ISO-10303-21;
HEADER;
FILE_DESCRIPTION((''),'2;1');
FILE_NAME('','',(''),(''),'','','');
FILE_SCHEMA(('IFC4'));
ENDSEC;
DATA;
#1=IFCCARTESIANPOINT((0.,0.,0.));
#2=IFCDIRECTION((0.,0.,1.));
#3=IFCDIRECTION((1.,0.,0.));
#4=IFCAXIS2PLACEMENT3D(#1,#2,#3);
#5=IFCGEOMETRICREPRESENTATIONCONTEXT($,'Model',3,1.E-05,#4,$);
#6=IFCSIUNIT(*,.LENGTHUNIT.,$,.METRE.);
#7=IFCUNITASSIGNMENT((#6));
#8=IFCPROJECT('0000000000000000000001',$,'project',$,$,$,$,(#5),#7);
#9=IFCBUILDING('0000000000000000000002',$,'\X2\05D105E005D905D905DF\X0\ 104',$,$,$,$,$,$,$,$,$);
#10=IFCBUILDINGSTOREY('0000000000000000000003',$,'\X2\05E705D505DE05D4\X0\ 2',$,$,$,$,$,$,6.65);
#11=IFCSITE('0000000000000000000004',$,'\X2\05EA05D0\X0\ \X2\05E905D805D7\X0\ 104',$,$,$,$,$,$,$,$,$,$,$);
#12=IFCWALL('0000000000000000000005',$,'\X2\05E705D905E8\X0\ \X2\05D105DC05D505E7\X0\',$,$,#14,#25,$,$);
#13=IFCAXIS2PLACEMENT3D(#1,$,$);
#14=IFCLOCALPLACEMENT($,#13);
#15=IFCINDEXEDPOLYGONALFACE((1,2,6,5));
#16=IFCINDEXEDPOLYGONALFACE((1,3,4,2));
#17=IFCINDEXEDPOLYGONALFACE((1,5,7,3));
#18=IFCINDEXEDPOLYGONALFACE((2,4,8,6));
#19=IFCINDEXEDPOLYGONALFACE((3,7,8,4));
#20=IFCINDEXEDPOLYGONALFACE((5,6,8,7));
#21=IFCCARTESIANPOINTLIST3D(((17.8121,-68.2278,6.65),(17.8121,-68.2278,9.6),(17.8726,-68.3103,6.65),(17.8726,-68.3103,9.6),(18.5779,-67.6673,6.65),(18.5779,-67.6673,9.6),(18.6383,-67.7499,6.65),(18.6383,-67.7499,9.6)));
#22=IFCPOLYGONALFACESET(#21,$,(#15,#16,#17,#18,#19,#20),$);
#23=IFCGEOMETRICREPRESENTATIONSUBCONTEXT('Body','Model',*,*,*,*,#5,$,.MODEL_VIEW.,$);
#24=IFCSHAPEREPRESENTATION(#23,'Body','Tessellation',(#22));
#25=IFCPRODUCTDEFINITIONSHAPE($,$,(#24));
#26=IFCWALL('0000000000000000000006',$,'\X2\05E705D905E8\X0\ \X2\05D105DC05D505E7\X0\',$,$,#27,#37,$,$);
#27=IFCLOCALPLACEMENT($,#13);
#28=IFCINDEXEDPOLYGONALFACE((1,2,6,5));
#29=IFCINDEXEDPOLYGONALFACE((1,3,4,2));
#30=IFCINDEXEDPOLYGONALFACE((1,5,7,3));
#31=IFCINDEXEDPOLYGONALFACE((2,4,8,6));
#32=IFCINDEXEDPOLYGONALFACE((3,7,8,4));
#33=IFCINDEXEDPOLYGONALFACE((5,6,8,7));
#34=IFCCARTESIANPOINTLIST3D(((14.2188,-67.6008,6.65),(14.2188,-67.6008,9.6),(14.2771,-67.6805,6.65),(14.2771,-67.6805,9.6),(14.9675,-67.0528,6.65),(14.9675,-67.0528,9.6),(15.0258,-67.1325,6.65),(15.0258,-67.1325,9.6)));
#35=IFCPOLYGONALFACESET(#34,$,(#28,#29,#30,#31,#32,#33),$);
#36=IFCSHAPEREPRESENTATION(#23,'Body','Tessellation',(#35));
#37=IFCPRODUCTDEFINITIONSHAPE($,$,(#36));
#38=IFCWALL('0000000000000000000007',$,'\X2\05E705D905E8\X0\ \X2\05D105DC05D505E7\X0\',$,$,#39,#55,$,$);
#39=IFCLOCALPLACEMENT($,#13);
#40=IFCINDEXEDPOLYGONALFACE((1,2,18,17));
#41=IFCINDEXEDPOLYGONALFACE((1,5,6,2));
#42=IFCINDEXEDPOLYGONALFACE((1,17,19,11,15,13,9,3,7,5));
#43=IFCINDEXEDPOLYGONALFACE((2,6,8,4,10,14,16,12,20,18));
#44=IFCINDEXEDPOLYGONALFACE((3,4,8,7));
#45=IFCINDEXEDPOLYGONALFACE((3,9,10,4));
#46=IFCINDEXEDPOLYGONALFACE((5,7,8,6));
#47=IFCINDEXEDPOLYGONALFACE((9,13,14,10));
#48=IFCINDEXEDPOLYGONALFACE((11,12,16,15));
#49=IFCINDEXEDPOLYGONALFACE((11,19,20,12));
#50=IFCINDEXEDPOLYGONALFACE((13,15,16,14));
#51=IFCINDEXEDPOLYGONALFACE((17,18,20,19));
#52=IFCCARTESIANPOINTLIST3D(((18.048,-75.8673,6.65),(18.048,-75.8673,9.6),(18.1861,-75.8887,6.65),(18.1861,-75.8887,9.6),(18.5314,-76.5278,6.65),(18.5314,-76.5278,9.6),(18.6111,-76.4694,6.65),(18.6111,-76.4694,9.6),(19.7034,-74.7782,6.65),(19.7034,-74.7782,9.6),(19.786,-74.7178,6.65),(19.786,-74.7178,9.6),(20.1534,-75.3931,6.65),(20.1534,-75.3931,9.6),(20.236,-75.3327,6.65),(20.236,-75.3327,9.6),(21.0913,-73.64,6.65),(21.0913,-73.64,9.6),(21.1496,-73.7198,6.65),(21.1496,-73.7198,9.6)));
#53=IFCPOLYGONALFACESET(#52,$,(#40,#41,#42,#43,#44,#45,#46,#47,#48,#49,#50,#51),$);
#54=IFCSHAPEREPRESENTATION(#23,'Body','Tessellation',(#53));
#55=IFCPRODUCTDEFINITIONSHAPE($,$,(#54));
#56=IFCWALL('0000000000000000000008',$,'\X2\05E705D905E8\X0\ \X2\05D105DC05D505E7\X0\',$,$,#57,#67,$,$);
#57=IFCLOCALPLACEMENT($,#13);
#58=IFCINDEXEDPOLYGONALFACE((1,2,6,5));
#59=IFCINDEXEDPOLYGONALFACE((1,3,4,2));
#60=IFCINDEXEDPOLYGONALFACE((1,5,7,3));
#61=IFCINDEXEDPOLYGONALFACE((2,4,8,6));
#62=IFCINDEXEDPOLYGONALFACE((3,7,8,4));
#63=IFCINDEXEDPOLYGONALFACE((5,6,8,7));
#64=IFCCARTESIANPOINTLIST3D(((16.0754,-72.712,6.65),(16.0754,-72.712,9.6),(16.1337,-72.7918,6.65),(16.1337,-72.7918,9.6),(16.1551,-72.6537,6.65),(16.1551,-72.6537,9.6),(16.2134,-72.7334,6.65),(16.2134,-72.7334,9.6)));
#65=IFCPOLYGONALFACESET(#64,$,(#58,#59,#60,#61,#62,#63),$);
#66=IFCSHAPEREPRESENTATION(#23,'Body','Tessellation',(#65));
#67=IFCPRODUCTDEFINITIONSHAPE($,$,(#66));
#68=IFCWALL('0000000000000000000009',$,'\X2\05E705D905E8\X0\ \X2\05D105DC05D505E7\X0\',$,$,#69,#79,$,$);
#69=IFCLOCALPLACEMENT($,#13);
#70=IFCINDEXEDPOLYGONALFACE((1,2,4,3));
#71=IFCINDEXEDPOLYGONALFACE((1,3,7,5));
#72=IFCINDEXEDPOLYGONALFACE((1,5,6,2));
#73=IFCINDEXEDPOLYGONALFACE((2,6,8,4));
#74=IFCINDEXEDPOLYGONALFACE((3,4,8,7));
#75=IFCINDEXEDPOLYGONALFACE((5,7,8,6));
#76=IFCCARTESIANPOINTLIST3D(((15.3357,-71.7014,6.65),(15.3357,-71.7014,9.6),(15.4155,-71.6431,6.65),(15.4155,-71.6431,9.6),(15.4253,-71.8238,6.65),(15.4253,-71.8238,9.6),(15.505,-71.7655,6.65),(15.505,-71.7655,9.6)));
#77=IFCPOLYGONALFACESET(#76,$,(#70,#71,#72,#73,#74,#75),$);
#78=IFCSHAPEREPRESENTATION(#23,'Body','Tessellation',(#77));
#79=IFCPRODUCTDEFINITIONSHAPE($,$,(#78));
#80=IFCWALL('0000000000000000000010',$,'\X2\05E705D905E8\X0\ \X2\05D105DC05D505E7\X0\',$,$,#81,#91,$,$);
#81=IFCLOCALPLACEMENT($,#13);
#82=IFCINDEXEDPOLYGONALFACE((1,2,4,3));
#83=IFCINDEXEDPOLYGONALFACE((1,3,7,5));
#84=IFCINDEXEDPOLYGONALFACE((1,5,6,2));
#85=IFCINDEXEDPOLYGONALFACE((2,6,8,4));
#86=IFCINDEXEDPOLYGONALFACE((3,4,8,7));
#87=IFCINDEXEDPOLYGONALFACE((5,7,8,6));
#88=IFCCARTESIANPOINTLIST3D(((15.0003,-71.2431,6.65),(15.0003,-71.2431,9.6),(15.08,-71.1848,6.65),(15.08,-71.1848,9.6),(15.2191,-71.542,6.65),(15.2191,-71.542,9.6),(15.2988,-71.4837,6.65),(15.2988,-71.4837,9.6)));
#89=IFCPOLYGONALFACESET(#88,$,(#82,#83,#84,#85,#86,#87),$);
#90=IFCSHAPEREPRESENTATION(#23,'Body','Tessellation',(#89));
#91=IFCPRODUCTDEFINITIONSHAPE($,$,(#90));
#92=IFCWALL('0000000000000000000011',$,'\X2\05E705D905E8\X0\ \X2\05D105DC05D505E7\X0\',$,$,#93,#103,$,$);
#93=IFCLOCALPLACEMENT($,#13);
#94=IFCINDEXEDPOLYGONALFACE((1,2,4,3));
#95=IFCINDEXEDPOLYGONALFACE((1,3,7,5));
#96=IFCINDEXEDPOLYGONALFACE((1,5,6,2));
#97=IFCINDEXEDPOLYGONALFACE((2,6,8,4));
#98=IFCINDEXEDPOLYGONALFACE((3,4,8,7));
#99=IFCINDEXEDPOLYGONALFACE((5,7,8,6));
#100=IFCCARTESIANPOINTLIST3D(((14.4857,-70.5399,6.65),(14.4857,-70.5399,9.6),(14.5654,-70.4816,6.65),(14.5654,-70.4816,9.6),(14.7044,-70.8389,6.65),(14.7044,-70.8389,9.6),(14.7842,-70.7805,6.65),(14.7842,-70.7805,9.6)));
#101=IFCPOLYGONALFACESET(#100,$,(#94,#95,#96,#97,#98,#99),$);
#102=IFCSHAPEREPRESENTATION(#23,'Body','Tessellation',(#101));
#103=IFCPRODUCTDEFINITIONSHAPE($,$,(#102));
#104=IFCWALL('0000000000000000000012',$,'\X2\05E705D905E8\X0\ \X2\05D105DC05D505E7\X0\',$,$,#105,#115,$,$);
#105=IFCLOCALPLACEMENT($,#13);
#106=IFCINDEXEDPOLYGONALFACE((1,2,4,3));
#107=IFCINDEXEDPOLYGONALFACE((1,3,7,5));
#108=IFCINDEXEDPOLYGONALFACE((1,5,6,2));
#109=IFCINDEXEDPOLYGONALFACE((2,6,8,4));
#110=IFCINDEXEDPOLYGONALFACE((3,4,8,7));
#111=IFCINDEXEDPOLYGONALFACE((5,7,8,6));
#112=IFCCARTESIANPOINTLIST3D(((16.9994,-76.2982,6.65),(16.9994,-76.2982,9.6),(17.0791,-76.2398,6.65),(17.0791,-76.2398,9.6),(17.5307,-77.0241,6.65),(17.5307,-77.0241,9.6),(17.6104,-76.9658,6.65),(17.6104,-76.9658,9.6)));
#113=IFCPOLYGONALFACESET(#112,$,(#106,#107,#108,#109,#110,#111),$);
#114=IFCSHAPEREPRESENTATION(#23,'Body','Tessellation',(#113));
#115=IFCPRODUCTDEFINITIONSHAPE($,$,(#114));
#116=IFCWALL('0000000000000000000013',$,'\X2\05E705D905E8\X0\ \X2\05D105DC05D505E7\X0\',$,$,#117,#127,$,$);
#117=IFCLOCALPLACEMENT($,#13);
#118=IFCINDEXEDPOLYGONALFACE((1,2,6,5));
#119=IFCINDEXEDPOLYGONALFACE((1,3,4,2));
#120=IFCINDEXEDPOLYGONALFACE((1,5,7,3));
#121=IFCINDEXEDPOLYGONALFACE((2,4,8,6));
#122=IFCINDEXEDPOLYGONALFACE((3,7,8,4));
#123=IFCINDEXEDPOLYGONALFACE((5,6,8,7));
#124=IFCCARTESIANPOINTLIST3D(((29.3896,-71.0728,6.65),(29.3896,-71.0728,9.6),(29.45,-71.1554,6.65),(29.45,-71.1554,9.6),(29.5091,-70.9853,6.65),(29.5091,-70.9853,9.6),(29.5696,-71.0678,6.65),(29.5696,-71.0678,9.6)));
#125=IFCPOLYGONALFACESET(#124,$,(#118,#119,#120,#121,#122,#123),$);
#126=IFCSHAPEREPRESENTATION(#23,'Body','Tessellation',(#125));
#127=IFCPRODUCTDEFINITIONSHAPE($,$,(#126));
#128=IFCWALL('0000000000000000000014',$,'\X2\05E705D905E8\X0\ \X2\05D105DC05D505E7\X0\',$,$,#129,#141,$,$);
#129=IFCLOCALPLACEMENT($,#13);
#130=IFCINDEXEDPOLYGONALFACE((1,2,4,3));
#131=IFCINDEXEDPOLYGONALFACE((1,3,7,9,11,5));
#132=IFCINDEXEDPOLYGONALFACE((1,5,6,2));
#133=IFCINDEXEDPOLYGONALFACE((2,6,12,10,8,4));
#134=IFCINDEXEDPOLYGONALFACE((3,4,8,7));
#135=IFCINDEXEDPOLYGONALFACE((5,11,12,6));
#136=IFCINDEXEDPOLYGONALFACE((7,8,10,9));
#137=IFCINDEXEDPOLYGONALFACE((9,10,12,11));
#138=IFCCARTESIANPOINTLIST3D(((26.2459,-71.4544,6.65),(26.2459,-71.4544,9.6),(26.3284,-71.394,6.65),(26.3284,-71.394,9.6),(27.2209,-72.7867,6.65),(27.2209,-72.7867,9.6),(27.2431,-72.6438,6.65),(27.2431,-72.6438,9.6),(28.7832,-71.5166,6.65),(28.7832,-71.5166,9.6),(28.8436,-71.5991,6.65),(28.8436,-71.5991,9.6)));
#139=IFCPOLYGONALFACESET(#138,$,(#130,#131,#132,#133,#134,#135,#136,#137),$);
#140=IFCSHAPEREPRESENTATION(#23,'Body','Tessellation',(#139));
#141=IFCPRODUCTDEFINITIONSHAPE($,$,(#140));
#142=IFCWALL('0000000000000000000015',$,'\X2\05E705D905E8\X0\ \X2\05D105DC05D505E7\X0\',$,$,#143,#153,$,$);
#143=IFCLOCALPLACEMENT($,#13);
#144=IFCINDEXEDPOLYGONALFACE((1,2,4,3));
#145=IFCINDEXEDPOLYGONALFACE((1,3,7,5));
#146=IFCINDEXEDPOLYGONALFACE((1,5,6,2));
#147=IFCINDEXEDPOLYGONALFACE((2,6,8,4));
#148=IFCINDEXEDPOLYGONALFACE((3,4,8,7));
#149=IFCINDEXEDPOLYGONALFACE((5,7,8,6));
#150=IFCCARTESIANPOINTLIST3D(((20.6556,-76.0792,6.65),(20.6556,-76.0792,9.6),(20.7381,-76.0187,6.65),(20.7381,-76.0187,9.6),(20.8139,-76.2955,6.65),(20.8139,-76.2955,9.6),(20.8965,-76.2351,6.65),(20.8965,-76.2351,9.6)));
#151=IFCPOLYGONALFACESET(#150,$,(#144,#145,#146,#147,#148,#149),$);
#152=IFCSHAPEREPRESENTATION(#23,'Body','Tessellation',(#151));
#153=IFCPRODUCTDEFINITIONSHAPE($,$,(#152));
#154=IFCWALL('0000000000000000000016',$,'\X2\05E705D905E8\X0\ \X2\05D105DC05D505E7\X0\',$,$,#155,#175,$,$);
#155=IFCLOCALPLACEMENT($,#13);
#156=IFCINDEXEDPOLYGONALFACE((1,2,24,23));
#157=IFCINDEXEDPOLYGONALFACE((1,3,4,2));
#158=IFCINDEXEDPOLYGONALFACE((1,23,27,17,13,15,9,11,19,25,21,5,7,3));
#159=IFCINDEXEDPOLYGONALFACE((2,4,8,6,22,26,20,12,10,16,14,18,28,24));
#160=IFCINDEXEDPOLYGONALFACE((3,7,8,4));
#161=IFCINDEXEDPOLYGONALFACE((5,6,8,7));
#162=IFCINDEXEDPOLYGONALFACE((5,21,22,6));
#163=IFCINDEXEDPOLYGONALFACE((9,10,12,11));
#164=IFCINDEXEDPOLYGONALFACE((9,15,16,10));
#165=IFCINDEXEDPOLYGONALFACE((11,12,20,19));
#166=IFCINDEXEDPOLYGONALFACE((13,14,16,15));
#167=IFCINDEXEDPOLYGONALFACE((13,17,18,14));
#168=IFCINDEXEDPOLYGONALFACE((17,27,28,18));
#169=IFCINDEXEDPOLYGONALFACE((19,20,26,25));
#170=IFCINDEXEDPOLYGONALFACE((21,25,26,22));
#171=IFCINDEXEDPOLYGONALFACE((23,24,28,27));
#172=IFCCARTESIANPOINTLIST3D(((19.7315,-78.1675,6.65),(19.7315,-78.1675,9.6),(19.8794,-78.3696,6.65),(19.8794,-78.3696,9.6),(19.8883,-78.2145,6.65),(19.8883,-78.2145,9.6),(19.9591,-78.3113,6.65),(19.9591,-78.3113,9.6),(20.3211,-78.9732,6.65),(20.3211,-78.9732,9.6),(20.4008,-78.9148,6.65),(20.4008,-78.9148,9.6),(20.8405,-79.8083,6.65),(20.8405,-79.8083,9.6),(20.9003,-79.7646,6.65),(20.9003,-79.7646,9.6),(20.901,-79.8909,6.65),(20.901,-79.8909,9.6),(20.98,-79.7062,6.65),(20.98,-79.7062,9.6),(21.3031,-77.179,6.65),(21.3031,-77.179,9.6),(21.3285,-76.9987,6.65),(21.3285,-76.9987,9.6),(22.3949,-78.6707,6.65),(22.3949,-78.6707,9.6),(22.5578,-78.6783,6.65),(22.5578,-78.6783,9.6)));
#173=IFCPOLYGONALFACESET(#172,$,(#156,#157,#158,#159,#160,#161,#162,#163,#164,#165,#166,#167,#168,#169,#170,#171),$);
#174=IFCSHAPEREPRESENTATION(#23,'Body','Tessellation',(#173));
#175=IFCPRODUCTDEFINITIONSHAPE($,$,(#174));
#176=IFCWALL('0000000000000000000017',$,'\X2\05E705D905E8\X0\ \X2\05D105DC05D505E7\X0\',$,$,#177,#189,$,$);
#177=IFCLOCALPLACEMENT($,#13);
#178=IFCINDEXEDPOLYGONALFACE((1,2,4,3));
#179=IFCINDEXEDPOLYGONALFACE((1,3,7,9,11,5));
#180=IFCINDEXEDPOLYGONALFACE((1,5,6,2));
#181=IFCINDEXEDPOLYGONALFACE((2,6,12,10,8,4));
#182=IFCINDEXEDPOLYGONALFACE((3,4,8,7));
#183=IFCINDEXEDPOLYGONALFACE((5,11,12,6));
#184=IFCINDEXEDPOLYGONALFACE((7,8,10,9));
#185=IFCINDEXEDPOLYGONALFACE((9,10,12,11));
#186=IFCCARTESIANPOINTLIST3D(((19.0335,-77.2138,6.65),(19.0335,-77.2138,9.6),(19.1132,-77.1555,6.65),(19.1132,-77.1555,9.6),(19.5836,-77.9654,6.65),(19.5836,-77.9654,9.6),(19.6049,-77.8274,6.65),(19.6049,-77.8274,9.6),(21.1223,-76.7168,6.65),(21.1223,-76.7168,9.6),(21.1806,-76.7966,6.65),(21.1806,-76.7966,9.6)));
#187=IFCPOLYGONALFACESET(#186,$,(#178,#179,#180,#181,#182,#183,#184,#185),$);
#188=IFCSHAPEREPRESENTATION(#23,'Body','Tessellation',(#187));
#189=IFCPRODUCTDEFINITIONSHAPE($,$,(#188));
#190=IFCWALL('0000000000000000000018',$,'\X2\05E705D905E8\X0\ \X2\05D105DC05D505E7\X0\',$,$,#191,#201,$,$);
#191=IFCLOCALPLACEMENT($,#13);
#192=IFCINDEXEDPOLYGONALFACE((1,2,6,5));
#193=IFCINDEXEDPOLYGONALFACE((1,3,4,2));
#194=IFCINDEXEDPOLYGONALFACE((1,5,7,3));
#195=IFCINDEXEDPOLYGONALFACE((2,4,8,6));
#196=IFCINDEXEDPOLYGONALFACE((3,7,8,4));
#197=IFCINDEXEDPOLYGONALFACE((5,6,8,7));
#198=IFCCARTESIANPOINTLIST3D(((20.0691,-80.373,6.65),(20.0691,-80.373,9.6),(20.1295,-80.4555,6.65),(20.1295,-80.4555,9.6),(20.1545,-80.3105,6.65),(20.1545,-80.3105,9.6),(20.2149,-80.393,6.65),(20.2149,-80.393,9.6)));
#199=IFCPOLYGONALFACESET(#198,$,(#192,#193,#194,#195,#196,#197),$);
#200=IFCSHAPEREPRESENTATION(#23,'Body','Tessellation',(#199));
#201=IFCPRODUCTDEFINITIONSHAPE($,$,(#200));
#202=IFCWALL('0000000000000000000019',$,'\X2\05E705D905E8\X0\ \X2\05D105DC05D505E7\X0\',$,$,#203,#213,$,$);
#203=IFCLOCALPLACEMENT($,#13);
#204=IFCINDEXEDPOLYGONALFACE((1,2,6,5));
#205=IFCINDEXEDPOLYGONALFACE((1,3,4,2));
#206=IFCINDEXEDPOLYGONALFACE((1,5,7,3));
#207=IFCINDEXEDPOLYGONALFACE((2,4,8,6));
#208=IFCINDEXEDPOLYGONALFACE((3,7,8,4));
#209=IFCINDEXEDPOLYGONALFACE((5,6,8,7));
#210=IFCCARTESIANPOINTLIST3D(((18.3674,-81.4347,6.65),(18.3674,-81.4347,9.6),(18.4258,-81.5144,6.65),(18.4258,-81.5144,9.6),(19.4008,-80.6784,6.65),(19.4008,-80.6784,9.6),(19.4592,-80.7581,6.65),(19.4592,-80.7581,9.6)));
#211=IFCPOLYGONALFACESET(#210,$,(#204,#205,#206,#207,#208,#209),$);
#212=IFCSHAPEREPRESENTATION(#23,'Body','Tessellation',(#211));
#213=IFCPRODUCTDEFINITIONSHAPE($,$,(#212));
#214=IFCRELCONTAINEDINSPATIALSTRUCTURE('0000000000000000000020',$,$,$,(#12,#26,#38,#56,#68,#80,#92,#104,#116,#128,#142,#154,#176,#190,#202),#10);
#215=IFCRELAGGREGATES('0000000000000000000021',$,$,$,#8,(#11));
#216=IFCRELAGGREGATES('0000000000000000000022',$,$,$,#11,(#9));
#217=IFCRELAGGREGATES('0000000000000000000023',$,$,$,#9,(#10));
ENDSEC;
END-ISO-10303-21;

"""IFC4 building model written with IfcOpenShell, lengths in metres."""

from ifc_helpers import new_model, si_unit, frame, origin_with_axes, context, subcontext, project, spatial, polyline, outline, extrude, element, save


model = new_model("IFC4")

# Units and contexts
model_context = context("Model", 3, precision=1e-05, world=origin_with_axes())
body_context = subcontext(model_context, "Body", "Model", "MODEL_VIEW")
ifc_project = project(units=[si_unit("LENGTHUNIT", "METRE")], contexts=[model_context])

# Site, building, storey
site = spatial("IfcSite", under=ifc_project, Name="תא שטח 104")
building = spatial("IfcBuilding", under=site, Name="בניין 104")
storey = spatial("IfcBuildingStorey", under=building, Name="קומה 2", Elevation=6.65)

# Walls
element("IfcWall", 1, inside=storey, Name="קיר בלוק", context=body_context, shape_type="SweptSolid", body=[
    extrude(outline(polyline([(18.5779, -67.6673), (17.8121, -68.2278), (17.8726, -68.3103), (18.6383, -67.7499), (18.5779, -67.6673)])), frame((0.0, 0.0, 6.65)), (0.0, 0.0, 1.0), 2.95),
])
element("IfcWall", 2, inside=storey, Name="קיר בלוק", context=body_context, shape_type="SweptSolid", body=[
    extrude(outline(polyline([(14.2188, -67.6008), (14.2771, -67.6805), (15.0258, -67.1325), (14.9675, -67.0528), (14.2188, -67.6008)])), frame((0.0, 0.0, 6.65)), (0.0, 0.0, 1.0), 2.95),
])
element("IfcWall", 3, inside=storey, Name="קיר בלוק", context=body_context, shape_type="SweptSolid", body=[
    extrude(outline(polyline([(21.0913, -73.64), (18.048, -75.8673), (18.5314, -76.5278), (18.6111, -76.4694), (18.1861, -75.8887), (19.7034, -74.7782), (20.1534, -75.3931), (20.236, -75.3327), (19.786, -74.7178), (21.1496, -73.7198), (21.0913, -73.64)])), frame((0.0, 0.0, 6.65)), (0.0, 0.0, 1.0), 2.95),
])
element("IfcWall", 4, inside=storey, Name="קיר בלוק", context=body_context, shape_type="SweptSolid", body=[
    extrude(outline(polyline([(16.1551, -72.6537), (16.0754, -72.712), (16.1337, -72.7918), (16.2134, -72.7334), (16.1551, -72.6537)])), frame((0.0, 0.0, 6.65)), (0.0, 0.0, 1.0), 2.95),
])
element("IfcWall", 5, inside=storey, Name="קיר בלוק", context=body_context, shape_type="SweptSolid", body=[
    extrude(outline(polyline([(15.505, -71.7655), (15.4155, -71.6431), (15.3357, -71.7014), (15.4253, -71.8238), (15.505, -71.7655)])), frame((0.0, 0.0, 6.65)), (0.0, 0.0, 1.0), 2.95),
])
element("IfcWall", 6, inside=storey, Name="קיר בלוק", context=body_context, shape_type="SweptSolid", body=[
    extrude(outline(polyline([(15.2988, -71.4837), (15.08, -71.1848), (15.0003, -71.2431), (15.2191, -71.542), (15.2988, -71.4837)])), frame((0.0, 0.0, 6.65)), (0.0, 0.0, 1.0), 2.95),
])
element("IfcWall", 7, inside=storey, Name="קיר בלוק", context=body_context, shape_type="SweptSolid", body=[
    extrude(outline(polyline([(14.7044, -70.8389), (14.7841, -70.7805), (14.5654, -70.4816), (14.4857, -70.5399), (14.7044, -70.8389)])), frame((0.0, 0.0, 6.65)), (0.0, 0.0, 1.0), 2.95),
])
element("IfcWall", 8, inside=storey, Name="קיר בלוק", context=body_context, shape_type="SweptSolid", body=[
    extrude(outline(polyline([(17.6104, -76.9658), (17.0791, -76.2398), (16.9994, -76.2982), (17.5307, -77.0241), (17.6104, -76.9658)])), frame((0.0, 0.0, 6.65)), (0.0, 0.0, 1.0), 2.95),
])
element("IfcWall", 9, inside=storey, Name="קיר בלוק", context=body_context, shape_type="SweptSolid", body=[
    extrude(outline(polyline([(29.45, -71.1553), (29.5696, -71.0678), (29.5091, -70.9853), (29.3896, -71.0728), (29.45, -71.1553)])), frame((0.0, 0.0, 6.65)), (0.0, 0.0, 1.0), 2.95),
])
element("IfcWall", 10, inside=storey, Name="קיר בלוק", context=body_context, shape_type="SweptSolid", body=[
    extrude(outline(polyline([(26.2459, -71.4544), (27.2209, -72.7867), (28.8436, -71.5991), (28.7832, -71.5166), (27.2431, -72.6438), (26.3284, -71.394), (26.2459, -71.4544)])), frame((0.0, 0.0, 6.65)), (0.0, 0.0, 1.0), 2.95),
])
element("IfcWall", 11, inside=storey, Name="קיר בלוק", context=body_context, shape_type="SweptSolid", body=[
    extrude(outline(polyline([(20.8965, -76.2351), (20.7381, -76.0187), (20.6556, -76.0792), (20.8139, -76.2955), (20.8965, -76.2351)])), frame((0.0, 0.0, 6.65)), (0.0, 0.0, 1.0), 2.95),
])
element("IfcWall", 12, inside=storey, Name="קיר בלוק", context=body_context, shape_type="SweptSolid", body=[
    extrude(outline(polyline([(19.7315, -78.1675), (19.8794, -78.3696), (19.9591, -78.3113), (19.8883, -78.2145), (21.3031, -77.179), (22.3949, -78.6707), (20.98, -79.7062), (20.4008, -78.9148), (20.3211, -78.9732), (20.9003, -79.7646), (20.8405, -79.8083), (20.901, -79.8909), (22.5578, -78.6783), (21.3285, -76.9987), (19.7315, -78.1675)])), frame((0.0, 0.0, 6.65)), (0.0, 0.0, 1.0), 2.95),
])
element("IfcWall", 13, inside=storey, Name="קיר בלוק", context=body_context, shape_type="SweptSolid", body=[
    extrude(outline(polyline([(19.0335, -77.2138), (19.5836, -77.9654), (21.1806, -76.7966), (21.1223, -76.7168), (19.6049, -77.8274), (19.1132, -77.1555), (19.0335, -77.2138)])), frame((0.0, 0.0, 6.65)), (0.0, 0.0, 1.0), 2.95),
])
element("IfcWall", 14, inside=storey, Name="קיר בלוק", context=body_context, shape_type="SweptSolid", body=[
    extrude(outline(polyline([(20.1545, -80.3105), (20.0691, -80.373), (20.1295, -80.4555), (20.2149, -80.393), (20.1545, -80.3105)])), frame((0.0, 0.0, 6.65)), (0.0, 0.0, 1.0), 2.95),
])
element("IfcWall", 15, inside=storey, Name="קיר בלוק", context=body_context, shape_type="SweptSolid", body=[
    extrude(outline(polyline([(19.4008, -80.6784), (18.3674, -81.4347), (18.4258, -81.5144), (19.4592, -80.7581), (19.4008, -80.6784)])), frame((0.0, 0.0, 6.65)), (0.0, 0.0, 1.0), 2.95),
])

save(model, "model.ifc")
